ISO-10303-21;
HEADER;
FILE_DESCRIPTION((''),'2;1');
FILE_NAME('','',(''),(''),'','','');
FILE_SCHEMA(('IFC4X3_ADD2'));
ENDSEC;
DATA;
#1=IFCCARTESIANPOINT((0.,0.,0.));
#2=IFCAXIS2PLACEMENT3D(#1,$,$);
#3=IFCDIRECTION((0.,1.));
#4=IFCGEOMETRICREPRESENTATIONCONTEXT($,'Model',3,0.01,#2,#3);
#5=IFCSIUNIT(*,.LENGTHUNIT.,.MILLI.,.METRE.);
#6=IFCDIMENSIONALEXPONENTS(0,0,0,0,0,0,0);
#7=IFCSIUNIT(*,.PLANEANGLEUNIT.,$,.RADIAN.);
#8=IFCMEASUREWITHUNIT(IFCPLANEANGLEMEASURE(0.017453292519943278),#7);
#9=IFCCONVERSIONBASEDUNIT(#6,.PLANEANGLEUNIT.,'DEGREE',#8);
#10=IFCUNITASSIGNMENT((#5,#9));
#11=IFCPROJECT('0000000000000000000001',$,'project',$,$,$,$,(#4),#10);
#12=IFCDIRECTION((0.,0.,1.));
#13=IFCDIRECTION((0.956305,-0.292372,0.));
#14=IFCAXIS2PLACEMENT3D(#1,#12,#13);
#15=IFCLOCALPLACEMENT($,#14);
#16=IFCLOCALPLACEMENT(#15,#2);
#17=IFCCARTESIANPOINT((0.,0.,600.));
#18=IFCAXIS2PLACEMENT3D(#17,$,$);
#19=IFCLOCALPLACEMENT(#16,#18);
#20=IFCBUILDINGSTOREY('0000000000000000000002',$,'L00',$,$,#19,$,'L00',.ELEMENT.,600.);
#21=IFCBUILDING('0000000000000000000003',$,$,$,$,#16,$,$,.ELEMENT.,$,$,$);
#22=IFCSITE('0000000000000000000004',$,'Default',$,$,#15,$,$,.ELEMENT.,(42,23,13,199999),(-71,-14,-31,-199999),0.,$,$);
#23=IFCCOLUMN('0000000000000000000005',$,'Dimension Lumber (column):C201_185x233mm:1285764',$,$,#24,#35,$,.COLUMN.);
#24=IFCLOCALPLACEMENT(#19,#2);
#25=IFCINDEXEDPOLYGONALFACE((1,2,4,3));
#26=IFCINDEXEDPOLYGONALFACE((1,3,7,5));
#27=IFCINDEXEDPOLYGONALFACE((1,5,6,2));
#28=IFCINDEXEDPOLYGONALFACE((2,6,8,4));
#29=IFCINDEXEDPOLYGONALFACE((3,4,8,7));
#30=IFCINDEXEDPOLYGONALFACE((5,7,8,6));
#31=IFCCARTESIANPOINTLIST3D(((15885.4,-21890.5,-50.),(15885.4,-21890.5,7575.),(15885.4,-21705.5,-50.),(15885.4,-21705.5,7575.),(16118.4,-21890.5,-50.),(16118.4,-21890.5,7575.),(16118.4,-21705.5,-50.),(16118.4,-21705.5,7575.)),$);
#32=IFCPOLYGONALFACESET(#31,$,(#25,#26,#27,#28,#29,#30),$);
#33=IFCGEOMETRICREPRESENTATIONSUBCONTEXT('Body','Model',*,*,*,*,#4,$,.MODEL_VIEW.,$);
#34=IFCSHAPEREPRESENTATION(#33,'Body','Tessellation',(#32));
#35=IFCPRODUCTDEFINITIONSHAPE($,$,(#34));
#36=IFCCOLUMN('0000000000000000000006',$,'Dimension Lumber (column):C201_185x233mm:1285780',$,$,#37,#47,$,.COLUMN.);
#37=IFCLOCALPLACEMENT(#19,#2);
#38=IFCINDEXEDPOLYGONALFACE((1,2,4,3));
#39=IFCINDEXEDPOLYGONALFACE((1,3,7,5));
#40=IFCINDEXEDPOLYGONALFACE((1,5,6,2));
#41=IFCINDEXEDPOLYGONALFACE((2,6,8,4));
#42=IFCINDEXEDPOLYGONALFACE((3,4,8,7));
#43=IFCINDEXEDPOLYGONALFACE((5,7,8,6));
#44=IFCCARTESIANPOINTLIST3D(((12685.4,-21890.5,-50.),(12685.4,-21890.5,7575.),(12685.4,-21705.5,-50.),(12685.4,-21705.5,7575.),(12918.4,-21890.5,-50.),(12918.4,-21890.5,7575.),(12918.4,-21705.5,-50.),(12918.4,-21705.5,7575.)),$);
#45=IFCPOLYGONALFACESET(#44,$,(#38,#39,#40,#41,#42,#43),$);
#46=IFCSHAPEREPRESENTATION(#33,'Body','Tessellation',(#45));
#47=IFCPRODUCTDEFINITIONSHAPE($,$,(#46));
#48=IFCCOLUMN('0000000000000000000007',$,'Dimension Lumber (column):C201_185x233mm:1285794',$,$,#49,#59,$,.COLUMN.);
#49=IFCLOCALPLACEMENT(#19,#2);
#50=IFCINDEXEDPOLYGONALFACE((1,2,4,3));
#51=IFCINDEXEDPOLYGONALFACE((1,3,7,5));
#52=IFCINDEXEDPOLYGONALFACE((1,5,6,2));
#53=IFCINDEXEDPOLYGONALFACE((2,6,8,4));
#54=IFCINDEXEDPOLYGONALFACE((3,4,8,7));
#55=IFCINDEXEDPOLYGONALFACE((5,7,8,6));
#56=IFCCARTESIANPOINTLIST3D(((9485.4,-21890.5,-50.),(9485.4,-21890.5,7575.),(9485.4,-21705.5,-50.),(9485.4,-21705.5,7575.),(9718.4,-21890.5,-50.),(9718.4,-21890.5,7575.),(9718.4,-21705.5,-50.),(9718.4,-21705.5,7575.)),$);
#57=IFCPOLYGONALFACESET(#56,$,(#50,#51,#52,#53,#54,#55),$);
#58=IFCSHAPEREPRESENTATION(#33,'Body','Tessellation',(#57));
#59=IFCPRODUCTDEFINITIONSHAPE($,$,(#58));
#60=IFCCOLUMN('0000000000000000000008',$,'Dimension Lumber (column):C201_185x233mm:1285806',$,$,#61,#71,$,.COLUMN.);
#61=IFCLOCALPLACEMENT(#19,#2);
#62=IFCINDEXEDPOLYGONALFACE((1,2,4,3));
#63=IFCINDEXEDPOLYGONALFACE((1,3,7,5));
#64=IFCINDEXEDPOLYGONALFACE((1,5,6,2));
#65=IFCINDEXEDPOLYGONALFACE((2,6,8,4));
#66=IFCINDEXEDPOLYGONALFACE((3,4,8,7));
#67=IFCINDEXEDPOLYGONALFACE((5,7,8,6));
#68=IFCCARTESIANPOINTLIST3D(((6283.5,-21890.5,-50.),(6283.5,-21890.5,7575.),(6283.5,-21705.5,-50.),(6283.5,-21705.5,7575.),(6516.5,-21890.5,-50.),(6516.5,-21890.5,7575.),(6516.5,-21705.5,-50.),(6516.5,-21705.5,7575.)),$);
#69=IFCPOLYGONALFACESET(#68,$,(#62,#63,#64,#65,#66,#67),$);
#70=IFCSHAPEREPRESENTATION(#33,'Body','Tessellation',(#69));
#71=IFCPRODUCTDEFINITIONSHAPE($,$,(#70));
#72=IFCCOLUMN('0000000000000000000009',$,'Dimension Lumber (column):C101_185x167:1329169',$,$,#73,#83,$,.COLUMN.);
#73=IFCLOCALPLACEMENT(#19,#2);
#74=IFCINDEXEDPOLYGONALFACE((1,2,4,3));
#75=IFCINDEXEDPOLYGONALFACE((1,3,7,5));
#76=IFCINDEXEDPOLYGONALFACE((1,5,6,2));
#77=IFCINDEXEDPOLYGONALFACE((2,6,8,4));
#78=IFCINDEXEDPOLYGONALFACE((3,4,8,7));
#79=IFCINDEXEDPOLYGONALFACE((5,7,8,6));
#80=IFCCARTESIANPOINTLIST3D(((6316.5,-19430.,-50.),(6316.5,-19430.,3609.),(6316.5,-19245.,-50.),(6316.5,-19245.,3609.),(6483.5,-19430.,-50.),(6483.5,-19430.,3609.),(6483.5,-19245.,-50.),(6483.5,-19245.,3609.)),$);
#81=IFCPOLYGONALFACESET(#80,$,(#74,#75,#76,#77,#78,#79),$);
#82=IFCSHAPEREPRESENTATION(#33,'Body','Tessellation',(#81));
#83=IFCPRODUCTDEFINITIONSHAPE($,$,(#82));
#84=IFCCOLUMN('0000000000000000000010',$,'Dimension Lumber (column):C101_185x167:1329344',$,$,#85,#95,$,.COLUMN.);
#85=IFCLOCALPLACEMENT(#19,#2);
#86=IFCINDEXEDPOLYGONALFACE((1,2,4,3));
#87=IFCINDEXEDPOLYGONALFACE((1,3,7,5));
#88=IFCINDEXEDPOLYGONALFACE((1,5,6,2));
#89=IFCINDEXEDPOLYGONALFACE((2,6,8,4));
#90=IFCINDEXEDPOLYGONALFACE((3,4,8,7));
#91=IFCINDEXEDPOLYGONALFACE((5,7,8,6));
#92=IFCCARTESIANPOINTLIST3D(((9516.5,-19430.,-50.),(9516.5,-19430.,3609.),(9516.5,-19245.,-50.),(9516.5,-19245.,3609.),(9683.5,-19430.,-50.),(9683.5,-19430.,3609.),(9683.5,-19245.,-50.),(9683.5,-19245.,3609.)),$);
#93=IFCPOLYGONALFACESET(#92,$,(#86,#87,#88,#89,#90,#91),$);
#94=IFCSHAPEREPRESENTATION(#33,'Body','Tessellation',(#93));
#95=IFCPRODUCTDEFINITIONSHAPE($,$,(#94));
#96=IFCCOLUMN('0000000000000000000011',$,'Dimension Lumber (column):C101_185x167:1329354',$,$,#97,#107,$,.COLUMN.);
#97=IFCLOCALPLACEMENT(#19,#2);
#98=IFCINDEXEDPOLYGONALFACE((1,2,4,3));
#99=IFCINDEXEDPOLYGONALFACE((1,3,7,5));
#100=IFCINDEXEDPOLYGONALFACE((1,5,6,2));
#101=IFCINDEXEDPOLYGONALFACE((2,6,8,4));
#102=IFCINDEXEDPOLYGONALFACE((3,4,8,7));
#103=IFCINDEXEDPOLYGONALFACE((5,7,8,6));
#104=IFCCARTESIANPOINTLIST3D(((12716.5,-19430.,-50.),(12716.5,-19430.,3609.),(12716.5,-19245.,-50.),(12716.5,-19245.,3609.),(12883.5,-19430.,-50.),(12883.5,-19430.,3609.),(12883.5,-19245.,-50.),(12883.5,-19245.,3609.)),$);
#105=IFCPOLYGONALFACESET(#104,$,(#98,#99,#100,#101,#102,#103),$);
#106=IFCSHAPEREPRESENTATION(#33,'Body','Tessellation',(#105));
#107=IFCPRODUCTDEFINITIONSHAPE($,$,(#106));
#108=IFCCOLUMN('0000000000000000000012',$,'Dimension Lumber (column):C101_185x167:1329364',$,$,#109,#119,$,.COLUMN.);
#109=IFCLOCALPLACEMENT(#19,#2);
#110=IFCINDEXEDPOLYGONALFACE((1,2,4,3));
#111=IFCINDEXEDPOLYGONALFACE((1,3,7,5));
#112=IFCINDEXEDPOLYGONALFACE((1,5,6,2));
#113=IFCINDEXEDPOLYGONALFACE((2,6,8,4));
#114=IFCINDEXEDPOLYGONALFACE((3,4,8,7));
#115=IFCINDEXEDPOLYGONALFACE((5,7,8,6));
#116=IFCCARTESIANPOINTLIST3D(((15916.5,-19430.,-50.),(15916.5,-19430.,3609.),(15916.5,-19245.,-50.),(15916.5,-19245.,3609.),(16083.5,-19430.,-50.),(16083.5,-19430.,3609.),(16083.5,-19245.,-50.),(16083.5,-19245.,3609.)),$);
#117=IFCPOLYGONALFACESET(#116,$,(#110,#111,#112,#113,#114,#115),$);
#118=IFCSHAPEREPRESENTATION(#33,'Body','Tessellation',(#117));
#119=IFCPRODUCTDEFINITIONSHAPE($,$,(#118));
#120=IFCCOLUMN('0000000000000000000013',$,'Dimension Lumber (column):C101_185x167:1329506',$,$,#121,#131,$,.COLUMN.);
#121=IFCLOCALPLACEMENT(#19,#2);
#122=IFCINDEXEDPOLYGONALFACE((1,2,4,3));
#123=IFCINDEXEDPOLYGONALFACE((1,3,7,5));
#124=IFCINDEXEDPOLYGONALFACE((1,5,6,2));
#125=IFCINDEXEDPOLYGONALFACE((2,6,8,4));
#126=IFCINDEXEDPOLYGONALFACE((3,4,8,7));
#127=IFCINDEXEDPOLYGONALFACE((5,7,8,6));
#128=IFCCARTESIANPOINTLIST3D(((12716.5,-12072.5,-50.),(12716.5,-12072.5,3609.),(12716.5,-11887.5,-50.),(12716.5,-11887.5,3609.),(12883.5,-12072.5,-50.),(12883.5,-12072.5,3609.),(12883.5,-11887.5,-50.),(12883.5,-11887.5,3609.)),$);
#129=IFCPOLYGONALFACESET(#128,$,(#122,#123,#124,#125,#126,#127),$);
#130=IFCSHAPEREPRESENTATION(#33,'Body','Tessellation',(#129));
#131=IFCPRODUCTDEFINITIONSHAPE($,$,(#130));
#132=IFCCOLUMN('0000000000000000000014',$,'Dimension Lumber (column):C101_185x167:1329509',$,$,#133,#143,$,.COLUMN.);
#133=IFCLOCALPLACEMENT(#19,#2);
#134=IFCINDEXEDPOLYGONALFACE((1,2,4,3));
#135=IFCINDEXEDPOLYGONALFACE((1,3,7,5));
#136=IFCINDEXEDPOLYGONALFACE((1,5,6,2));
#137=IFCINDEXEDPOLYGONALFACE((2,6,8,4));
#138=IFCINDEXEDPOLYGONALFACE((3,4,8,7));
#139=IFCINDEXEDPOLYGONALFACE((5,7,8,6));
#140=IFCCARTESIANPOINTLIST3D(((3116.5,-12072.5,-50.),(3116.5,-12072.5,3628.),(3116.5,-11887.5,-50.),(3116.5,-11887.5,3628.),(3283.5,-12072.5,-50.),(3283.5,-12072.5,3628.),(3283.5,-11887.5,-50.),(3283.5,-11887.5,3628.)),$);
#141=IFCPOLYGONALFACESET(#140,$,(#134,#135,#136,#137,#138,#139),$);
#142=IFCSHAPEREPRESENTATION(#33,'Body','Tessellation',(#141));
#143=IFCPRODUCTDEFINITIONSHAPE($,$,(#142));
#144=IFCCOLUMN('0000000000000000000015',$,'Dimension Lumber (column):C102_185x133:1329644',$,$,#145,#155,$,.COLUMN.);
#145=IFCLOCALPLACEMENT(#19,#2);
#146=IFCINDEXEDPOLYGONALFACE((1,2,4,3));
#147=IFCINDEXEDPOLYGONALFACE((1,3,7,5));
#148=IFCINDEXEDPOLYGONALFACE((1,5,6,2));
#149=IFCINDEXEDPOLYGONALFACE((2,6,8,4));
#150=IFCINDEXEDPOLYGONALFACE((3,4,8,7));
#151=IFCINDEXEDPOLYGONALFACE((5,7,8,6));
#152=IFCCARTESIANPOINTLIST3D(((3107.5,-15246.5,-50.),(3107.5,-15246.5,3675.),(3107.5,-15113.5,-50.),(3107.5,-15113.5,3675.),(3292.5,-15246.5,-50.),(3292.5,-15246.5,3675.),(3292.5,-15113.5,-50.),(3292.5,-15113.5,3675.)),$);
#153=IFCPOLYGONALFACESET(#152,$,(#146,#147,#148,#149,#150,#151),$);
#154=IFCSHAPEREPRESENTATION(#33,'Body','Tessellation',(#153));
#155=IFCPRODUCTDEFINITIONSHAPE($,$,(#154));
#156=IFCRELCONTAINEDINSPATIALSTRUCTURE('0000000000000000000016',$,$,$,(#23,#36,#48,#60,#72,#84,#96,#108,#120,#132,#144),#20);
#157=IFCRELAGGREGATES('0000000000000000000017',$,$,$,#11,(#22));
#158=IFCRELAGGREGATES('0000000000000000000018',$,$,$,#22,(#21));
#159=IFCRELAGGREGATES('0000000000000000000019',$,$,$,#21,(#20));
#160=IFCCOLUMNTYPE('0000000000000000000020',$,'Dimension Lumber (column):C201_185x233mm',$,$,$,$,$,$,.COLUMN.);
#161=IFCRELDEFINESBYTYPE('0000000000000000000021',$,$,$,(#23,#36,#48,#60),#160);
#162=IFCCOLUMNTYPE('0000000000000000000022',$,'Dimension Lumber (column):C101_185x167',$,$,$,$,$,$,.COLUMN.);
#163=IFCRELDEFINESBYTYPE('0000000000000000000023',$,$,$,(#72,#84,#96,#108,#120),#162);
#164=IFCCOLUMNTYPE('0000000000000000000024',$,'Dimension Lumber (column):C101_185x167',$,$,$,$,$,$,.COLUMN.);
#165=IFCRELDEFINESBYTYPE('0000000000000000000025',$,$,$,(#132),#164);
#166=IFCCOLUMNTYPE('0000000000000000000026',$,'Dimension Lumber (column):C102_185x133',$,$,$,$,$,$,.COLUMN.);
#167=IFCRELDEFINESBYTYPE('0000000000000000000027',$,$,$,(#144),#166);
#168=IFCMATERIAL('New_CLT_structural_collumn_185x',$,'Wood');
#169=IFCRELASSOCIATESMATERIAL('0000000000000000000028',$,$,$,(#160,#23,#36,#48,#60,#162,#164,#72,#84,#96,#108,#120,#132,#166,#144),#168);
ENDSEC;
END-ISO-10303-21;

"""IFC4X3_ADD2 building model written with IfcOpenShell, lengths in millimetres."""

from ifc_helpers import new_model, entity, si_unit, converted_unit, direction, frame, origin, origin_2d_with_axis, place, context, subcontext, project, spatial, rectangle, extrude, source, transform, mapped, material, material_profile, profile_set, profile_usage, type_object, type_shapes, element, save


model = new_model("IFC4X3_ADD2")

# Units and contexts
model_context = context("Model", 3, precision=0.01, world=origin(), true_north=direction((0.0, 1.0)))
body_context = subcontext(model_context, "Body", "Model", "MODEL_VIEW")
ifc_project = project(units=[si_unit("LENGTHUNIT", "METRE", prefix="MILLI"), converted_unit("PLANEANGLEUNIT", "DEGREE", entity("IfcPlaneAngleMeasure", 0.017453292519943278), si_unit("PLANEANGLEUNIT", "RADIAN"), dimensions=[0, 0, 0, 0, 0, 0, 0])], contexts=[model_context])

# Site, building, storey
site_placement = place(None, frame((0.0, 0.0, 0.0), z_axis=(0.0, 0.0, 1.0), x_axis=(0.956305, -0.292372, 0.0)))
site = spatial("IfcSite", under=ifc_project, at=site_placement, Name="Default", CompositionType="ELEMENT", RefLatitude=(42, 23, 13, 199999), RefLongitude=(-71, -14, -31, -199999), RefElevation=0.0)
building_placement = place(site_placement, origin())
building = spatial("IfcBuilding", under=site, at=building_placement, CompositionType="ELEMENT")
storey_placement = place(building_placement, frame((0.0, 0.0, 600.0)))
storey = spatial("IfcBuildingStorey", under=building, at=storey_placement, Name="L00", LongName="L00", CompositionType="ELEMENT", Elevation=600.0)

# Columns
ifc_material_1 = material(Name="New_CLT_structural_collumn_185x", Category="Wood")
ifc_material_profile_1 = material_profile(ifc_material_1, rectangle(XDim=185.0, YDim=233.0, at=origin_2d_with_axis()), Name="C201_185x233mm")
ifc_profile_set_1 = profile_set([ifc_material_profile_1], Name="C201_185x233mm")
ifc_profile_usage_1 = profile_usage(ifc_profile_set_1)
column_type_1 = type_object("IfcColumnType", Name="Dimension Lumber (column):C201_185x233mm", PredefinedType="COLUMN", material=ifc_profile_set_1)
shared_shape_1 = source(origin(), body_context, "Body", "SweptSolid", [
    extrude(rectangle(XDim=185.0, YDim=233.0, at=origin_2d_with_axis()), frame((0.0, 0.0, 550.0), z_axis=(0.0, 0.0, 1.0), x_axis=(-1.0, 0.0, 0.0)), (0.0, 0.0, 1.0), 7625.0),
])
type_shapes(column_type_1, [shared_shape_1])
for number, where, z_axis, x_axis, name in (
    (1, (16001.9, -21798.0, -600.0), (0.0, 0.0, 1.0), (0.0, 1.0, 0.0), "Dimension Lumber (column):C201_185x233mm:1285764"),
    (2, (12801.9, -21798.0, -600.0), (0.0, 0.0, 1.0), (0.0, 1.0, 0.0), "Dimension Lumber (column):C201_185x233mm:1285780"),
    (3, (9601.9, -21798.0, -600.0), (0.0, 0.0, 1.0), (0.0, 1.0, 0.0), "Dimension Lumber (column):C201_185x233mm:1285794"),
    (4, (6400.0, -21798.0, -600.0), (0.0, 0.0, 1.0), (0.0, 1.0, 0.0), "Dimension Lumber (column):C201_185x233mm:1285806"),
):
    element("IfcColumn", number, at=place(storey_placement, frame(where, z_axis=z_axis, x_axis=x_axis)), inside=storey, type_object=column_type_1, material=ifc_profile_usage_1, Name=name, PredefinedType="COLUMN", context=body_context, shape_type="MappedRepresentation", body=[
        mapped(shared_shape_1, transform((0.0, 0.0, 0.0), scale=1.0)),
    ])
ifc_material_profile_2 = material_profile(ifc_material_1, rectangle(XDim=185.0, YDim=167.0, at=origin_2d_with_axis()), Name="C101_185x167")
ifc_profile_set_2 = profile_set([ifc_material_profile_2], Name="C101_185x167")
ifc_profile_usage_2 = profile_usage(ifc_profile_set_2)
column_type_2 = type_object("IfcColumnType", Name="Dimension Lumber (column):C101_185x167", PredefinedType="COLUMN", material=ifc_profile_set_2)
shared_shape_2 = source(origin(), body_context, "Body", "SweptSolid", [
    extrude(rectangle(XDim=185.0, YDim=167.0, at=origin_2d_with_axis()), frame((0.0, 0.0, 550.0), z_axis=(0.0, 0.0, 1.0), x_axis=(-1.0, 0.0, 0.0)), (0.0, 0.0, 1.0), 3659.0),
])
type_shapes(column_type_2, [shared_shape_2])
for number, where, z_axis, x_axis, name in (
    (5, (6400.0, -19337.5, -600.0), (0.0, 0.0, 1.0), (0.0, 1.0, 0.0), "Dimension Lumber (column):C101_185x167:1329169"),
    (6, (9600.0, -19337.5, -600.0), (0.0, 0.0, 1.0), (0.0, 1.0, 0.0), "Dimension Lumber (column):C101_185x167:1329344"),
    (7, (12800.0, -19337.5, -600.0), (0.0, 0.0, 1.0), (0.0, 1.0, 0.0), "Dimension Lumber (column):C101_185x167:1329354"),
    (8, (16000.0, -19337.5, -600.0), (0.0, 0.0, 1.0), (0.0, 1.0, 0.0), "Dimension Lumber (column):C101_185x167:1329364"),
    (9, (12800.0, -11980.0, -600.0), (0.0, 0.0, 1.0), (0.0, 1.0, 0.0), "Dimension Lumber (column):C101_185x167:1329506"),
):
    element("IfcColumn", number, at=place(storey_placement, frame(where, z_axis=z_axis, x_axis=x_axis)), inside=storey, type_object=column_type_2, material=ifc_profile_usage_2, Name=name, PredefinedType="COLUMN", context=body_context, shape_type="MappedRepresentation", body=[
        mapped(shared_shape_2, transform((0.0, 0.0, 0.0), scale=1.0)),
    ])
column_type_3 = type_object("IfcColumnType", Name="Dimension Lumber (column):C101_185x167", PredefinedType="COLUMN", material=ifc_profile_set_2)
shared_shape_3 = source(origin(), body_context, "Body", "SweptSolid", [
    extrude(rectangle(XDim=185.0, YDim=167.0, at=origin_2d_with_axis()), frame((0.0, 0.0, 550.0), z_axis=(0.0, 0.0, 1.0), x_axis=(-1.0, 0.0, 0.0)), (0.0, 0.0, 1.0), 3678.0),
])
type_shapes(column_type_3, [shared_shape_3])
column_1_placement = place(storey_placement, frame((3200.0, -11980.0, -600.0), z_axis=(0.0, 0.0, 1.0), x_axis=(0.0, 1.0, 0.0)))
element("IfcColumn", 10, at=column_1_placement, inside=storey, type_object=column_type_3, material=ifc_profile_usage_2, Name="Dimension Lumber (column):C101_185x167:1329509", PredefinedType="COLUMN", context=body_context, shape_type="MappedRepresentation", body=[
    mapped(shared_shape_3, transform((0.0, 0.0, 0.0), scale=1.0)),
])
ifc_material_profile_3 = material_profile(ifc_material_1, rectangle(XDim=185.0, YDim=133.0, at=origin_2d_with_axis()), Name="C102_185x133")
ifc_profile_set_3 = profile_set([ifc_material_profile_3], Name="C102_185x133")
ifc_profile_usage_3 = profile_usage(ifc_profile_set_3)
column_type_4 = type_object("IfcColumnType", Name="Dimension Lumber (column):C102_185x133", PredefinedType="COLUMN", material=ifc_profile_set_3)
shared_shape_4 = source(origin(), body_context, "Body", "SweptSolid", [
    extrude(rectangle(XDim=185.0, YDim=133.0, at=origin_2d_with_axis()), frame((0.0, 0.0, 550.0), z_axis=(0.0, 0.0, 1.0), x_axis=(-1.0, 0.0, 0.0)), (0.0, 0.0, 1.0), 3725.0),
])
type_shapes(column_type_4, [shared_shape_4])
column_2_placement = place(storey_placement, frame((3200.0, -15180.0, -600.0), z_axis=(0.0, 0.0, 1.0), x_axis=(-1.0, 0.0, 0.0)))
element("IfcColumn", 11, at=column_2_placement, inside=storey, type_object=column_type_4, material=ifc_profile_usage_3, Name="Dimension Lumber (column):C102_185x133:1329644", PredefinedType="COLUMN", context=body_context, shape_type="MappedRepresentation", body=[
    mapped(shared_shape_4, transform((0.0, 0.0, 0.0), scale=1.0)),
])

save(model, "model.ifc")
